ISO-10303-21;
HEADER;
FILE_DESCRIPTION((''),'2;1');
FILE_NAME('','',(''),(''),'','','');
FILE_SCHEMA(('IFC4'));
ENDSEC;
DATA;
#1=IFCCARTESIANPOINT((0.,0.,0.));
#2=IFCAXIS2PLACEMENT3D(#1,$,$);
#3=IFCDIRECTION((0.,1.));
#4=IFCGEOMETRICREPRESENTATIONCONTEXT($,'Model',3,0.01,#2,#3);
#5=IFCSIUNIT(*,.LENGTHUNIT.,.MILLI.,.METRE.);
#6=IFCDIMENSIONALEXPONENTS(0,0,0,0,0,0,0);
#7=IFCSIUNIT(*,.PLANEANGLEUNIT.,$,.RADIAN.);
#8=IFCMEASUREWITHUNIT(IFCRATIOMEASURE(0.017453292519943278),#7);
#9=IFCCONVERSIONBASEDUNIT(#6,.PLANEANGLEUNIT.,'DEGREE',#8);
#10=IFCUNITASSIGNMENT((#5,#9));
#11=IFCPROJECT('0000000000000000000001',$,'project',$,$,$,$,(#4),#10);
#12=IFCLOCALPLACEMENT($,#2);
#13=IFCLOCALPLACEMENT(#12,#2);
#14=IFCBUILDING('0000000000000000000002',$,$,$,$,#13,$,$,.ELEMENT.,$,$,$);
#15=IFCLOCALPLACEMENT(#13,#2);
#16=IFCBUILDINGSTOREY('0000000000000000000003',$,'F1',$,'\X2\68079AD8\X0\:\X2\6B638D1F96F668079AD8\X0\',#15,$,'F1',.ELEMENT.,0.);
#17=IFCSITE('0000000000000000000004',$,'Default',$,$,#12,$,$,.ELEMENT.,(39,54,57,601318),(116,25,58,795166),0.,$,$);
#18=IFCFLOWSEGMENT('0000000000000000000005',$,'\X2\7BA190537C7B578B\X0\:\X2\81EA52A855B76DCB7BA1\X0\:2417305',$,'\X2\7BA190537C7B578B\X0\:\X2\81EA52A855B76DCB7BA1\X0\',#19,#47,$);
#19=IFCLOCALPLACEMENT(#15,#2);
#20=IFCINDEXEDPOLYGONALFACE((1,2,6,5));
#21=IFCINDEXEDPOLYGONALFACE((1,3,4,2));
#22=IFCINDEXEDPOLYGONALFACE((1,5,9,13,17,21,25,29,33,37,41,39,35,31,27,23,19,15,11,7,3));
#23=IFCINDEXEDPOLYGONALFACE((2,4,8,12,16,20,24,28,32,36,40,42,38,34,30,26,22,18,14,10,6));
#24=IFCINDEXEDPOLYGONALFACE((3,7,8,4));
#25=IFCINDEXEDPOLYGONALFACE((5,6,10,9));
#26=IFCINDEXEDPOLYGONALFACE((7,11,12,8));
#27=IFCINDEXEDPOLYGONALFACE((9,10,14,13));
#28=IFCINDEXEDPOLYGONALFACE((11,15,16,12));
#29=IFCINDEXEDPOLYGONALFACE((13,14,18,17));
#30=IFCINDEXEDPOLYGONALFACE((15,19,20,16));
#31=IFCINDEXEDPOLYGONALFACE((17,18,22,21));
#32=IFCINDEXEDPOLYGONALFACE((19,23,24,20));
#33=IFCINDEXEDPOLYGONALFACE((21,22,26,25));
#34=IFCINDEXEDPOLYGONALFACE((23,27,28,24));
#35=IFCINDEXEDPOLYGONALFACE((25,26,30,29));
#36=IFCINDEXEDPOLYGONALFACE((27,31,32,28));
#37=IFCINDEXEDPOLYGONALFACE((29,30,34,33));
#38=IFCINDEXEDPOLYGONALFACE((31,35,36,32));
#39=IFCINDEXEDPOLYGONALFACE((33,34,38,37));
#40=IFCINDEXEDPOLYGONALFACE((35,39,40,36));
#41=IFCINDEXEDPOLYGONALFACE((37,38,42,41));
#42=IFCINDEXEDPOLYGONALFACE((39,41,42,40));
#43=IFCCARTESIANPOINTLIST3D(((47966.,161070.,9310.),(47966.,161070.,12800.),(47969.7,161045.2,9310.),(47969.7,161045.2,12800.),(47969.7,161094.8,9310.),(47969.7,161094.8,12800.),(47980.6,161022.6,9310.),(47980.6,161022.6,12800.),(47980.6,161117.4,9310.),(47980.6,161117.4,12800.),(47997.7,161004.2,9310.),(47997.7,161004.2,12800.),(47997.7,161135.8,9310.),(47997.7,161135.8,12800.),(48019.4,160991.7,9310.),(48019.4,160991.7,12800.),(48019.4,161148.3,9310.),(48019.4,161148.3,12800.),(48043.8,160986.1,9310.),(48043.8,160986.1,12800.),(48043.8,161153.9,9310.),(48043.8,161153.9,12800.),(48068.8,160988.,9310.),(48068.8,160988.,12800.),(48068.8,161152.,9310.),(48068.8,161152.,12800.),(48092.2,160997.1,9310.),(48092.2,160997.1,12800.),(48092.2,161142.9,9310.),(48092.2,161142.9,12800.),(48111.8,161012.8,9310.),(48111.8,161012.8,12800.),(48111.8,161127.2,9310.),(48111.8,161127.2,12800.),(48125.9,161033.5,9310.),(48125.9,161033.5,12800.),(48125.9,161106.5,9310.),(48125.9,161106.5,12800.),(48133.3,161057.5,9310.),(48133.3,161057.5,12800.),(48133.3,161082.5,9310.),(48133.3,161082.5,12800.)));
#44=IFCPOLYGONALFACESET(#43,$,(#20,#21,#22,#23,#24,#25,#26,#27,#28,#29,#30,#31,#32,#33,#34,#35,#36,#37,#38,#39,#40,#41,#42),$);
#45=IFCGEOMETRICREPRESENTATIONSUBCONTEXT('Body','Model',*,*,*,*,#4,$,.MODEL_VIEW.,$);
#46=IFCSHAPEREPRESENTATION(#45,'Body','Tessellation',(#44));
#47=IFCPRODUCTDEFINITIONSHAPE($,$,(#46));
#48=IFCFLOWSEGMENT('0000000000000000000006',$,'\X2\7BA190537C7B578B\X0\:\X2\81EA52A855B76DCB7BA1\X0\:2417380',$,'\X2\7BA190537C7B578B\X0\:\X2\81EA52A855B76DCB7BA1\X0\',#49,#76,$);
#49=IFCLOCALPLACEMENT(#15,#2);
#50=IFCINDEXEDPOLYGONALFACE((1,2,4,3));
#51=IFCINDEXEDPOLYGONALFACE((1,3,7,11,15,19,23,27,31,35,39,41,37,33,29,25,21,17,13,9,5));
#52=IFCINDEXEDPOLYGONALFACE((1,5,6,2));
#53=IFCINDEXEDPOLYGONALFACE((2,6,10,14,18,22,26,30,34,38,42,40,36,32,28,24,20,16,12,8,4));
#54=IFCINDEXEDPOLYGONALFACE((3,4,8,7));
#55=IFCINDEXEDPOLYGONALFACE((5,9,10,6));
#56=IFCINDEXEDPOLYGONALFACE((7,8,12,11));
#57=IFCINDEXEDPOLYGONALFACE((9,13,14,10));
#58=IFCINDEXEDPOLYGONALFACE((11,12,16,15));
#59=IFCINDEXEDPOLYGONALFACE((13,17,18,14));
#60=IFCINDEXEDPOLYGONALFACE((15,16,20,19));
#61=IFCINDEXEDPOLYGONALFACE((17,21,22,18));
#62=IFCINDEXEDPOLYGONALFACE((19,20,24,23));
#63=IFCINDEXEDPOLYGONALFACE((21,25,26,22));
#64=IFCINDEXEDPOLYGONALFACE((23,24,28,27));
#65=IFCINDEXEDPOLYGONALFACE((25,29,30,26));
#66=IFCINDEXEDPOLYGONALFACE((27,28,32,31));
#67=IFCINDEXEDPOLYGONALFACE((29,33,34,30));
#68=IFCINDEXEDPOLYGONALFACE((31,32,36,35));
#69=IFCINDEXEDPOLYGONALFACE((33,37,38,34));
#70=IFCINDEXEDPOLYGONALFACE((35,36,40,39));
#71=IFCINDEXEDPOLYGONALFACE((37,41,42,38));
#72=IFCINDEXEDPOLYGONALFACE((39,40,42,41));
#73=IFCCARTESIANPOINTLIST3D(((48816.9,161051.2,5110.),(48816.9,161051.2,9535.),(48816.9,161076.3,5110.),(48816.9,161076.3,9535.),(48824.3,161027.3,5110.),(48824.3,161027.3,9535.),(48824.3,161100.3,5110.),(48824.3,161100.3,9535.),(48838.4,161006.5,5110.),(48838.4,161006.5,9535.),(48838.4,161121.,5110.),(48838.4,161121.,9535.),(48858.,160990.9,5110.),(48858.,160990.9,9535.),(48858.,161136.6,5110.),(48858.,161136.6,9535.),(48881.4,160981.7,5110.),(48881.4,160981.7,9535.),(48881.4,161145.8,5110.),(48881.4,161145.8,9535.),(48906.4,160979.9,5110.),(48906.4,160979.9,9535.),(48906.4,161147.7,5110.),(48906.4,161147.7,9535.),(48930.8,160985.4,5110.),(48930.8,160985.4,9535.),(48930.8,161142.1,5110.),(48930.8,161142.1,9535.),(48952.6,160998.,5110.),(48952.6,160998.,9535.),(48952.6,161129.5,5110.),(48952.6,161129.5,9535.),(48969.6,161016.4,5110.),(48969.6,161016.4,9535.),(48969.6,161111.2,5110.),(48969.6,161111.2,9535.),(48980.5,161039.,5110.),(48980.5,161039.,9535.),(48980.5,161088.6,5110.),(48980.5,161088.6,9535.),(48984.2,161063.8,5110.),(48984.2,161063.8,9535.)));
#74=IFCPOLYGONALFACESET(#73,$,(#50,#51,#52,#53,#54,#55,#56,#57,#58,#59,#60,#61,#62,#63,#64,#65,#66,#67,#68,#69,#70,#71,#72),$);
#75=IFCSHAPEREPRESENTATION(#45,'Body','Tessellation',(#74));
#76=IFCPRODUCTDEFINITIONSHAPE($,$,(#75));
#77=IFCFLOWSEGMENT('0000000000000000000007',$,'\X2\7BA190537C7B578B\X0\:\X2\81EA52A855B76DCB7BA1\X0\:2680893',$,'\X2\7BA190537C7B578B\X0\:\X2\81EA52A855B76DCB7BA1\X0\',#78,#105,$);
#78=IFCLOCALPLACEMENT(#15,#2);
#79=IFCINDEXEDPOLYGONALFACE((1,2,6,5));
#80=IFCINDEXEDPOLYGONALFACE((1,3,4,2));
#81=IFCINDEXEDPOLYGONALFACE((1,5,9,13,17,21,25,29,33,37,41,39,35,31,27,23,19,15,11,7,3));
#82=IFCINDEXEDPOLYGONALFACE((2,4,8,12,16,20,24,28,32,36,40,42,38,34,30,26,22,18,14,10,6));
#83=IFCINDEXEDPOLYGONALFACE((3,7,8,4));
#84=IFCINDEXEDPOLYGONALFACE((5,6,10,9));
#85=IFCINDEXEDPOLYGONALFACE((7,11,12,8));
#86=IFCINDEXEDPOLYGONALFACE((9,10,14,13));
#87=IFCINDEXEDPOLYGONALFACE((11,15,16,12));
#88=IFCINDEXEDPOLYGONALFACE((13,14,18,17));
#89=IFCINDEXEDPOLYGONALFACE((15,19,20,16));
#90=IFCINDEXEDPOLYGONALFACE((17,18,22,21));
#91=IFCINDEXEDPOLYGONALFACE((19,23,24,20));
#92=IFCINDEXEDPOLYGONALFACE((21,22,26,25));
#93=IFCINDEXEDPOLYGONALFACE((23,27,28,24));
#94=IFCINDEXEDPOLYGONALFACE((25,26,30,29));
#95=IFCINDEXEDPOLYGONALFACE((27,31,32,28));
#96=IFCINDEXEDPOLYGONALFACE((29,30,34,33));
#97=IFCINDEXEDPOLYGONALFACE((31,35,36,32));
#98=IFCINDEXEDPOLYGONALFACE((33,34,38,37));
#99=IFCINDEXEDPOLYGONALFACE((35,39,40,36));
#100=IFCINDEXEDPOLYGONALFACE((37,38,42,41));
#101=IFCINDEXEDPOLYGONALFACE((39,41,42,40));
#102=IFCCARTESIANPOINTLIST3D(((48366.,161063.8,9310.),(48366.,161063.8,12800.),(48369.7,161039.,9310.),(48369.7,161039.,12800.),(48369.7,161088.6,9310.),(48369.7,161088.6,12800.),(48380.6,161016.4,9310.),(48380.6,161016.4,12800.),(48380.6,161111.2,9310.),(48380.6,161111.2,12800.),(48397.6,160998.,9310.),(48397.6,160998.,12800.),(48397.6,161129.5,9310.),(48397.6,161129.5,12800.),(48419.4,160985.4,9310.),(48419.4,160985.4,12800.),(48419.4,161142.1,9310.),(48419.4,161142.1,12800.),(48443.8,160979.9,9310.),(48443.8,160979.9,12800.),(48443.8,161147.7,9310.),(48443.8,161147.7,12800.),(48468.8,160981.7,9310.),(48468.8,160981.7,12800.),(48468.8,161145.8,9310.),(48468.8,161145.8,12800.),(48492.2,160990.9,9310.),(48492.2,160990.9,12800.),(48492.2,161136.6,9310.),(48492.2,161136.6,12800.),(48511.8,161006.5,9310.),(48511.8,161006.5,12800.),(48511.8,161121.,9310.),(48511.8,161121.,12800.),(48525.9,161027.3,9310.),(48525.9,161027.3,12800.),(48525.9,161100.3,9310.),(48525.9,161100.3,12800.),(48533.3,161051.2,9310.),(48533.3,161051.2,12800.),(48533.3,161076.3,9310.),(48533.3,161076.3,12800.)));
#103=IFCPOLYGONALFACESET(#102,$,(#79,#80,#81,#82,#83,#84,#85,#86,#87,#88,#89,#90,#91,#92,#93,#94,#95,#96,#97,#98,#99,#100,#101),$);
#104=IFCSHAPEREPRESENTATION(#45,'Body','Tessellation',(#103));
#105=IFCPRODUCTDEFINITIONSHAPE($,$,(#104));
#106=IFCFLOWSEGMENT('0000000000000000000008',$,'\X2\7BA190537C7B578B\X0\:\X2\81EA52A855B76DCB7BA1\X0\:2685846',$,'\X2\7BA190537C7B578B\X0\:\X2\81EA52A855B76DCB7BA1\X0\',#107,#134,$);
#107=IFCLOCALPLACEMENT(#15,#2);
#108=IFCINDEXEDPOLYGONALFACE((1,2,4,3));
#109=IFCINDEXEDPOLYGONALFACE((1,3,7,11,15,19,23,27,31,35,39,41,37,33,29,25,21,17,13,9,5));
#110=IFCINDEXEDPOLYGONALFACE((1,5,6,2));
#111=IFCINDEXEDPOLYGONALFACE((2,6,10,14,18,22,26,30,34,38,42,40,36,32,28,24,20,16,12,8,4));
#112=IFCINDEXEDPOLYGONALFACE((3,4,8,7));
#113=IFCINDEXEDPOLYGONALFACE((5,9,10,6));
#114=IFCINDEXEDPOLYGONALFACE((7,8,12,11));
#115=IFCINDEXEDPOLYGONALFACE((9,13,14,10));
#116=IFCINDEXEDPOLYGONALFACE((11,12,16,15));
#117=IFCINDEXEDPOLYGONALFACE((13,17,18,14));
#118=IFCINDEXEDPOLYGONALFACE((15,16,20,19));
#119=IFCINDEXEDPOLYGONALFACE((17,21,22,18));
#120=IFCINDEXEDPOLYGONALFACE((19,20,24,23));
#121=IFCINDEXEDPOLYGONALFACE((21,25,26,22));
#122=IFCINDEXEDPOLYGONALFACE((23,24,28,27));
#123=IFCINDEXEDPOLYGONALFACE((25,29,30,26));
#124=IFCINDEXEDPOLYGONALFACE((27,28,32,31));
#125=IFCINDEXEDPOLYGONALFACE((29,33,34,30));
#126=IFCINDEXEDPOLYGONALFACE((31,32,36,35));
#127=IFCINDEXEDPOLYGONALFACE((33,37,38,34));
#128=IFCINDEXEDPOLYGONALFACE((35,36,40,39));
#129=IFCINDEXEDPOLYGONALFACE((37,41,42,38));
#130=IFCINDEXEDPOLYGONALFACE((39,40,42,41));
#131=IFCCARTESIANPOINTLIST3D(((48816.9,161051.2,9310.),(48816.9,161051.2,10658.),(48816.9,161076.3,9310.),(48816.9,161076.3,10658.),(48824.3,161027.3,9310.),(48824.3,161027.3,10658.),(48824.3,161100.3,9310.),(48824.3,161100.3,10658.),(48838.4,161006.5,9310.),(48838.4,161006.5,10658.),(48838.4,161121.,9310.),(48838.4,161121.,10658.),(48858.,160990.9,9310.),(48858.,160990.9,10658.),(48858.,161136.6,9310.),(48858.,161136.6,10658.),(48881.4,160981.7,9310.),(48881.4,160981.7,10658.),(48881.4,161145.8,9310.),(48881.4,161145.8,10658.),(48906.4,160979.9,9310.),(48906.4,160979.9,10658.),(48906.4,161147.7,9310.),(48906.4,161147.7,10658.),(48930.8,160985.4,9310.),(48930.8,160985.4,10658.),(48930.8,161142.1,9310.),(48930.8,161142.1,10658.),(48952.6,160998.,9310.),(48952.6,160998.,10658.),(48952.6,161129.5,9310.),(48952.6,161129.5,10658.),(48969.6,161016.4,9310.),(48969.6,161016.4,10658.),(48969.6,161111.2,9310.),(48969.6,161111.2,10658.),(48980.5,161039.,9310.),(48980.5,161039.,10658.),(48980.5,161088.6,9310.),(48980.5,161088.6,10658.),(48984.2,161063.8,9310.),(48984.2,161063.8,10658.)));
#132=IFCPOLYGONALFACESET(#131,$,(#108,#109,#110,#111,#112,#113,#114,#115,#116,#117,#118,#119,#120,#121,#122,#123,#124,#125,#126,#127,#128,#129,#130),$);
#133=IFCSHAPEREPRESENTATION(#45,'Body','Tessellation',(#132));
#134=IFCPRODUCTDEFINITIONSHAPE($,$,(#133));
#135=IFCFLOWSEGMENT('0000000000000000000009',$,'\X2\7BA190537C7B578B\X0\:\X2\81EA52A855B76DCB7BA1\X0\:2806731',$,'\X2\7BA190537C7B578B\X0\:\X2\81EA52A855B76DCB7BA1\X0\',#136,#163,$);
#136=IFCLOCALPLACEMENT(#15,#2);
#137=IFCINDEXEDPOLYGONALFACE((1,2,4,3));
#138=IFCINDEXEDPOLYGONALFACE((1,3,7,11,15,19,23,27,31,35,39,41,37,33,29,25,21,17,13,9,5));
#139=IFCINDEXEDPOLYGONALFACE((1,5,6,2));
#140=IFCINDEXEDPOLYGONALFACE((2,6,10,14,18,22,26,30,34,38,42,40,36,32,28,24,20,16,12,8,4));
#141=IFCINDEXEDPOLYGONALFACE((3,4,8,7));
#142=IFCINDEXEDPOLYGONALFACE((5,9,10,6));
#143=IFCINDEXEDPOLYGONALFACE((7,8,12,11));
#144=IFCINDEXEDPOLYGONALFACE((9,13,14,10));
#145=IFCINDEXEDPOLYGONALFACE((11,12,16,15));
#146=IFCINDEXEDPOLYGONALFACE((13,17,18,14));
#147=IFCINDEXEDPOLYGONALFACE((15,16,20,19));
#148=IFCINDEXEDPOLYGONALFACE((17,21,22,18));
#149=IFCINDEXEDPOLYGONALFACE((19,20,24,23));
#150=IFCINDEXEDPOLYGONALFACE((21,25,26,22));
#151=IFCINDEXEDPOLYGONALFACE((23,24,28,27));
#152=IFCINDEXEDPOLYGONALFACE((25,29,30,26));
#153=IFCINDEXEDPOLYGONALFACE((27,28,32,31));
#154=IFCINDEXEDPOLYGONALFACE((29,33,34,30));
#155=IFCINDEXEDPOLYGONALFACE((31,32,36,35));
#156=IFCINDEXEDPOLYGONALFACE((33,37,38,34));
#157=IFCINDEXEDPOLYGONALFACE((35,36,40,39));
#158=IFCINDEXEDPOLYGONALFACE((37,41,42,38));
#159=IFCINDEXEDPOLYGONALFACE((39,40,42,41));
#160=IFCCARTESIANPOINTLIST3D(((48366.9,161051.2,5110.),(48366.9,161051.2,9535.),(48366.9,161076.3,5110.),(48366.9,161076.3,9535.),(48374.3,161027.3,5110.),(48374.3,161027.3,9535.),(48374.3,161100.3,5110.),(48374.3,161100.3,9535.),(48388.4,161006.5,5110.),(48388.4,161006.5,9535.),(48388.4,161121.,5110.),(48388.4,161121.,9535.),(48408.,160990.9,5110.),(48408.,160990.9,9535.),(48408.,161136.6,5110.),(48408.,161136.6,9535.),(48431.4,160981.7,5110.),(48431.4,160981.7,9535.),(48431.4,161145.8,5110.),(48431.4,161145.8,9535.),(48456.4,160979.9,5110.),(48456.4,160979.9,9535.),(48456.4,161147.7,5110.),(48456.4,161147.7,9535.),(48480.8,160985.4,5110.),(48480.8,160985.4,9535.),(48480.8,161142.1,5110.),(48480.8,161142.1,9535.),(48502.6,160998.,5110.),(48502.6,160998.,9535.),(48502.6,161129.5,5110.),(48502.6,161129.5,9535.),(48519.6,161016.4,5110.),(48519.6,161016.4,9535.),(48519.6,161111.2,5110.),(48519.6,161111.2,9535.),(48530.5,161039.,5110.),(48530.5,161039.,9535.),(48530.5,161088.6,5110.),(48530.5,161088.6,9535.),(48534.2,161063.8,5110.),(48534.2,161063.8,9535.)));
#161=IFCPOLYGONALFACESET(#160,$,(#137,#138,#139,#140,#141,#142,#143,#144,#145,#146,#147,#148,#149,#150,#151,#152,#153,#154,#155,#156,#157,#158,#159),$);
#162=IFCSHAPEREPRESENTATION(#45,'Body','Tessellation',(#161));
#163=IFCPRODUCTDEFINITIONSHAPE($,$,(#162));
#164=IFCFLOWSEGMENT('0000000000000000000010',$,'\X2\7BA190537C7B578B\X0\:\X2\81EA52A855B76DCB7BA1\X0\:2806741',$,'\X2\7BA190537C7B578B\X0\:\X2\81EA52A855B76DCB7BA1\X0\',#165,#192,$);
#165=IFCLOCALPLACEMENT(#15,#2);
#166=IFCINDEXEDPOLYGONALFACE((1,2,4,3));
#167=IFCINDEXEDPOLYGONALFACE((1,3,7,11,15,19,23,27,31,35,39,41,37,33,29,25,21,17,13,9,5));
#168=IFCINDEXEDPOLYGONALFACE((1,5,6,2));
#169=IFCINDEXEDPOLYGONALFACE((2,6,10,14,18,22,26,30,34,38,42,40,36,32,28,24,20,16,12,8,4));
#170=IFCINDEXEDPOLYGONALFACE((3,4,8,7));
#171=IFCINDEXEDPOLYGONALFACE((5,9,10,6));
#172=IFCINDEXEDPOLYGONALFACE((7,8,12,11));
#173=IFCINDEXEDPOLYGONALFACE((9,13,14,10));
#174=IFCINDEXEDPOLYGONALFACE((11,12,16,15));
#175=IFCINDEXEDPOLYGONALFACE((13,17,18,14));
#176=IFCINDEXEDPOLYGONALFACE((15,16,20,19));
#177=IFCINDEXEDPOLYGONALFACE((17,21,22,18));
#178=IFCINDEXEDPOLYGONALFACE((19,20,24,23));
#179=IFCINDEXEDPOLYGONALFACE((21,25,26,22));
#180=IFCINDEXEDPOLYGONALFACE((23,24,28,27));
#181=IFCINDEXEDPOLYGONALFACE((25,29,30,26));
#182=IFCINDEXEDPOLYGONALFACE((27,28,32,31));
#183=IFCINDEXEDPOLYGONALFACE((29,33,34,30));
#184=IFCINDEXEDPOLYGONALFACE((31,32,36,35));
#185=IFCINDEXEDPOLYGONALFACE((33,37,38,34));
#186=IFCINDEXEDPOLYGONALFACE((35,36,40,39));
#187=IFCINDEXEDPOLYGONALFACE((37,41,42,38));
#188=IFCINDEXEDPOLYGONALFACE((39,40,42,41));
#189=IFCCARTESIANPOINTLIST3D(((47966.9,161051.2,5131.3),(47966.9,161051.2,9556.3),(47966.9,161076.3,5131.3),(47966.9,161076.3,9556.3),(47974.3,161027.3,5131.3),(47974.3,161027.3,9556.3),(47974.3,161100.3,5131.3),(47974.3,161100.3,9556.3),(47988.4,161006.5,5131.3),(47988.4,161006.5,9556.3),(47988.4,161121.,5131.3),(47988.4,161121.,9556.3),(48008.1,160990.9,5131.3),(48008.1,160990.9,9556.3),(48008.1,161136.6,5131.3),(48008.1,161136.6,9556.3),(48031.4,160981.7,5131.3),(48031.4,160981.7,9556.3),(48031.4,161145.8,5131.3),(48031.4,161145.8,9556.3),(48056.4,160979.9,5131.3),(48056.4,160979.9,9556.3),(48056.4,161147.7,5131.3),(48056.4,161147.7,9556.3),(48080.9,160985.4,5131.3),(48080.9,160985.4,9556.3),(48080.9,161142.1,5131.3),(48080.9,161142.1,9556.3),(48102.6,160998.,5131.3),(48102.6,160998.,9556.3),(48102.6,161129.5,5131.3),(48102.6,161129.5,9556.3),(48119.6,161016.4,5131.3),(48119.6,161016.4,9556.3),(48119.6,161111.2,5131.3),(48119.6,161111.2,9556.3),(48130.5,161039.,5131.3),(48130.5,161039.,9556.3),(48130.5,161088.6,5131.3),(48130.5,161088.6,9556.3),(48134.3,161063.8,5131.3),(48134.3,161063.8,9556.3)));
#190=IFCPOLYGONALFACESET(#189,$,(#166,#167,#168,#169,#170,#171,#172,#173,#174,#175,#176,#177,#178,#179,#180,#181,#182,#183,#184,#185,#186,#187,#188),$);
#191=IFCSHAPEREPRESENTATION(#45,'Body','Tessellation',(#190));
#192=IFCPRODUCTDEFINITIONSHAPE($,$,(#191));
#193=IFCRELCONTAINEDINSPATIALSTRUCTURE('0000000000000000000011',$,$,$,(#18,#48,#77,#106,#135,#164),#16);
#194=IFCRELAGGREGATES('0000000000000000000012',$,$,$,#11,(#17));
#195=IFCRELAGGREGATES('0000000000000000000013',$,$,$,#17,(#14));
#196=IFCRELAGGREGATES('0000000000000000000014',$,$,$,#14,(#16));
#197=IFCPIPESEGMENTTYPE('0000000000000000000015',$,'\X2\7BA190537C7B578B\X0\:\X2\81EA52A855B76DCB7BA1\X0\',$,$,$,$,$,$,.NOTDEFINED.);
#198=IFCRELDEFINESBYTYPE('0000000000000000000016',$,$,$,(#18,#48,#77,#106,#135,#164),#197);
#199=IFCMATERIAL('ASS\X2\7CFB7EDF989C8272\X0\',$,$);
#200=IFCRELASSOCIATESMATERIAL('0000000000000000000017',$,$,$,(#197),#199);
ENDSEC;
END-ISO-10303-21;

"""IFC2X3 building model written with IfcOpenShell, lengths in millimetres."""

from ifc_helpers import new_model, entity, si_unit, converted_unit, direction, frame, frame_2d, origin, origin_2d_with_axis, place, context, subcontext, project, spatial, circle, extrude, material, type_object, element, save


model = new_model("IFC2X3")

# Units and contexts
model_context = context("Model", 3, precision=0.01, world=origin(), true_north=direction((0.0, 1.0)))
body_context = subcontext(model_context, "Body", "Model", "MODEL_VIEW")
ifc_project = project(units=[si_unit("LENGTHUNIT", "METRE", prefix="MILLI"), converted_unit("PLANEANGLEUNIT", "DEGREE", entity("IfcRatioMeasure", 0.017453292519943278), si_unit("PLANEANGLEUNIT", "RADIAN"), dimensions=[0, 0, 0, 0, 0, 0, 0])], contexts=[model_context])

# Site, building, storey
site_placement = place(None, origin())
site = spatial("IfcSite", under=ifc_project, at=site_placement, Name="Default", CompositionType="ELEMENT", RefLatitude=(39, 54, 57, 601318), RefLongitude=(116, 25, 58, 795166), RefElevation=0.0)
building_placement = place(site_placement, origin())
building = spatial("IfcBuilding", under=site, at=building_placement, CompositionType="ELEMENT")
storey_placement = place(building_placement, origin())
storey = spatial("IfcBuildingStorey", under=building, at=storey_placement, Name="F1", ObjectType="标高:正负零标高", LongName="F1", CompositionType="ELEMENT", Elevation=0.0)

# Flow segments
ifc_material_1 = material(Name="ASS系统颜色")
pipe_segment_type_1 = type_object("IfcPipeSegmentType", Name="管道类型:自动喷淋管", PredefinedType="NOTDEFINED", material=ifc_material_1)
flow_segment_1_placement = place(storey_placement, origin())
element("IfcFlowSegment", 1, at=flow_segment_1_placement, inside=storey, type_object=pipe_segment_type_1, Name="管道类型:自动喷淋管:2417305", ObjectType="管道类型:自动喷淋管", context=body_context, shape_type="SweptSolid", body=[
    extrude(circle(Radius=84.1, at=origin_2d_with_axis()), frame((48050.1, 161070.0, 9310.0), z_axis=(0.0, 0.0, 1.0), x_axis=(-1.0, 0.0, 0.0)), (0.0, 0.0, 1.0), 3490.0),
])
flow_segment_2_placement = place(storey_placement, origin())
element("IfcFlowSegment", 2, at=flow_segment_2_placement, inside=storey, type_object=pipe_segment_type_1, Name="管道类型:自动喷淋管:2417380", ObjectType="管道类型:自动喷淋管", context=body_context, shape_type="SweptSolid", body=[
    extrude(circle(Radius=84.1, at=origin_2d_with_axis()), frame((48900.1, 161063.8, 5110.0)), (0.0, 0.0, 1.0), 4425.0),
])
flow_segment_3_placement = place(storey_placement, origin())
element("IfcFlowSegment", 3, at=flow_segment_3_placement, inside=storey, type_object=pipe_segment_type_1, Name="管道类型:自动喷淋管:2680893", ObjectType="管道类型:自动喷淋管", context=body_context, shape_type="SweptSolid", body=[
    extrude(circle(Radius=84.1, at=frame_2d((0.0, 0.0), x_axis=(1.0, 0.0))), frame((48450.1, 161063.8, 9310.0), z_axis=(0.0, 0.0, 1.0), x_axis=(-1.0, 0.0, 0.0)), (0.0, 0.0, 1.0), 3490.0),
])
flow_segment_4_placement = place(storey_placement, origin())
element("IfcFlowSegment", 4, at=flow_segment_4_placement, inside=storey, type_object=pipe_segment_type_1, Name="管道类型:自动喷淋管:2685846", ObjectType="管道类型:自动喷淋管", context=body_context, shape_type="SweptSolid", body=[
    extrude(circle(Radius=84.1, at=origin_2d_with_axis()), frame((48900.1, 161063.8, 9310.0)), (0.0, 0.0, 1.0), 1348.0),
])
flow_segment_5_placement = place(storey_placement, origin())
element("IfcFlowSegment", 5, at=flow_segment_5_placement, inside=storey, type_object=pipe_segment_type_1, Name="管道类型:自动喷淋管:2806731", ObjectType="管道类型:自动喷淋管", context=body_context, shape_type="SweptSolid", body=[
    extrude(circle(Radius=84.1, at=origin_2d_with_axis()), frame((48450.1, 161063.8, 5110.0)), (0.0, 0.0, 1.0), 4425.0),
])
flow_segment_6_placement = place(storey_placement, origin())
element("IfcFlowSegment", 6, at=flow_segment_6_placement, inside=storey, type_object=pipe_segment_type_1, Name="管道类型:自动喷淋管:2806741", ObjectType="管道类型:自动喷淋管", context=body_context, shape_type="SweptSolid", body=[
    extrude(circle(Radius=84.1, at=origin_2d_with_axis()), frame((48050.1, 161063.8, 5131.3)), (0.0, 0.0, 1.0), 4425.0),
])

save(model, "model.ifc")
